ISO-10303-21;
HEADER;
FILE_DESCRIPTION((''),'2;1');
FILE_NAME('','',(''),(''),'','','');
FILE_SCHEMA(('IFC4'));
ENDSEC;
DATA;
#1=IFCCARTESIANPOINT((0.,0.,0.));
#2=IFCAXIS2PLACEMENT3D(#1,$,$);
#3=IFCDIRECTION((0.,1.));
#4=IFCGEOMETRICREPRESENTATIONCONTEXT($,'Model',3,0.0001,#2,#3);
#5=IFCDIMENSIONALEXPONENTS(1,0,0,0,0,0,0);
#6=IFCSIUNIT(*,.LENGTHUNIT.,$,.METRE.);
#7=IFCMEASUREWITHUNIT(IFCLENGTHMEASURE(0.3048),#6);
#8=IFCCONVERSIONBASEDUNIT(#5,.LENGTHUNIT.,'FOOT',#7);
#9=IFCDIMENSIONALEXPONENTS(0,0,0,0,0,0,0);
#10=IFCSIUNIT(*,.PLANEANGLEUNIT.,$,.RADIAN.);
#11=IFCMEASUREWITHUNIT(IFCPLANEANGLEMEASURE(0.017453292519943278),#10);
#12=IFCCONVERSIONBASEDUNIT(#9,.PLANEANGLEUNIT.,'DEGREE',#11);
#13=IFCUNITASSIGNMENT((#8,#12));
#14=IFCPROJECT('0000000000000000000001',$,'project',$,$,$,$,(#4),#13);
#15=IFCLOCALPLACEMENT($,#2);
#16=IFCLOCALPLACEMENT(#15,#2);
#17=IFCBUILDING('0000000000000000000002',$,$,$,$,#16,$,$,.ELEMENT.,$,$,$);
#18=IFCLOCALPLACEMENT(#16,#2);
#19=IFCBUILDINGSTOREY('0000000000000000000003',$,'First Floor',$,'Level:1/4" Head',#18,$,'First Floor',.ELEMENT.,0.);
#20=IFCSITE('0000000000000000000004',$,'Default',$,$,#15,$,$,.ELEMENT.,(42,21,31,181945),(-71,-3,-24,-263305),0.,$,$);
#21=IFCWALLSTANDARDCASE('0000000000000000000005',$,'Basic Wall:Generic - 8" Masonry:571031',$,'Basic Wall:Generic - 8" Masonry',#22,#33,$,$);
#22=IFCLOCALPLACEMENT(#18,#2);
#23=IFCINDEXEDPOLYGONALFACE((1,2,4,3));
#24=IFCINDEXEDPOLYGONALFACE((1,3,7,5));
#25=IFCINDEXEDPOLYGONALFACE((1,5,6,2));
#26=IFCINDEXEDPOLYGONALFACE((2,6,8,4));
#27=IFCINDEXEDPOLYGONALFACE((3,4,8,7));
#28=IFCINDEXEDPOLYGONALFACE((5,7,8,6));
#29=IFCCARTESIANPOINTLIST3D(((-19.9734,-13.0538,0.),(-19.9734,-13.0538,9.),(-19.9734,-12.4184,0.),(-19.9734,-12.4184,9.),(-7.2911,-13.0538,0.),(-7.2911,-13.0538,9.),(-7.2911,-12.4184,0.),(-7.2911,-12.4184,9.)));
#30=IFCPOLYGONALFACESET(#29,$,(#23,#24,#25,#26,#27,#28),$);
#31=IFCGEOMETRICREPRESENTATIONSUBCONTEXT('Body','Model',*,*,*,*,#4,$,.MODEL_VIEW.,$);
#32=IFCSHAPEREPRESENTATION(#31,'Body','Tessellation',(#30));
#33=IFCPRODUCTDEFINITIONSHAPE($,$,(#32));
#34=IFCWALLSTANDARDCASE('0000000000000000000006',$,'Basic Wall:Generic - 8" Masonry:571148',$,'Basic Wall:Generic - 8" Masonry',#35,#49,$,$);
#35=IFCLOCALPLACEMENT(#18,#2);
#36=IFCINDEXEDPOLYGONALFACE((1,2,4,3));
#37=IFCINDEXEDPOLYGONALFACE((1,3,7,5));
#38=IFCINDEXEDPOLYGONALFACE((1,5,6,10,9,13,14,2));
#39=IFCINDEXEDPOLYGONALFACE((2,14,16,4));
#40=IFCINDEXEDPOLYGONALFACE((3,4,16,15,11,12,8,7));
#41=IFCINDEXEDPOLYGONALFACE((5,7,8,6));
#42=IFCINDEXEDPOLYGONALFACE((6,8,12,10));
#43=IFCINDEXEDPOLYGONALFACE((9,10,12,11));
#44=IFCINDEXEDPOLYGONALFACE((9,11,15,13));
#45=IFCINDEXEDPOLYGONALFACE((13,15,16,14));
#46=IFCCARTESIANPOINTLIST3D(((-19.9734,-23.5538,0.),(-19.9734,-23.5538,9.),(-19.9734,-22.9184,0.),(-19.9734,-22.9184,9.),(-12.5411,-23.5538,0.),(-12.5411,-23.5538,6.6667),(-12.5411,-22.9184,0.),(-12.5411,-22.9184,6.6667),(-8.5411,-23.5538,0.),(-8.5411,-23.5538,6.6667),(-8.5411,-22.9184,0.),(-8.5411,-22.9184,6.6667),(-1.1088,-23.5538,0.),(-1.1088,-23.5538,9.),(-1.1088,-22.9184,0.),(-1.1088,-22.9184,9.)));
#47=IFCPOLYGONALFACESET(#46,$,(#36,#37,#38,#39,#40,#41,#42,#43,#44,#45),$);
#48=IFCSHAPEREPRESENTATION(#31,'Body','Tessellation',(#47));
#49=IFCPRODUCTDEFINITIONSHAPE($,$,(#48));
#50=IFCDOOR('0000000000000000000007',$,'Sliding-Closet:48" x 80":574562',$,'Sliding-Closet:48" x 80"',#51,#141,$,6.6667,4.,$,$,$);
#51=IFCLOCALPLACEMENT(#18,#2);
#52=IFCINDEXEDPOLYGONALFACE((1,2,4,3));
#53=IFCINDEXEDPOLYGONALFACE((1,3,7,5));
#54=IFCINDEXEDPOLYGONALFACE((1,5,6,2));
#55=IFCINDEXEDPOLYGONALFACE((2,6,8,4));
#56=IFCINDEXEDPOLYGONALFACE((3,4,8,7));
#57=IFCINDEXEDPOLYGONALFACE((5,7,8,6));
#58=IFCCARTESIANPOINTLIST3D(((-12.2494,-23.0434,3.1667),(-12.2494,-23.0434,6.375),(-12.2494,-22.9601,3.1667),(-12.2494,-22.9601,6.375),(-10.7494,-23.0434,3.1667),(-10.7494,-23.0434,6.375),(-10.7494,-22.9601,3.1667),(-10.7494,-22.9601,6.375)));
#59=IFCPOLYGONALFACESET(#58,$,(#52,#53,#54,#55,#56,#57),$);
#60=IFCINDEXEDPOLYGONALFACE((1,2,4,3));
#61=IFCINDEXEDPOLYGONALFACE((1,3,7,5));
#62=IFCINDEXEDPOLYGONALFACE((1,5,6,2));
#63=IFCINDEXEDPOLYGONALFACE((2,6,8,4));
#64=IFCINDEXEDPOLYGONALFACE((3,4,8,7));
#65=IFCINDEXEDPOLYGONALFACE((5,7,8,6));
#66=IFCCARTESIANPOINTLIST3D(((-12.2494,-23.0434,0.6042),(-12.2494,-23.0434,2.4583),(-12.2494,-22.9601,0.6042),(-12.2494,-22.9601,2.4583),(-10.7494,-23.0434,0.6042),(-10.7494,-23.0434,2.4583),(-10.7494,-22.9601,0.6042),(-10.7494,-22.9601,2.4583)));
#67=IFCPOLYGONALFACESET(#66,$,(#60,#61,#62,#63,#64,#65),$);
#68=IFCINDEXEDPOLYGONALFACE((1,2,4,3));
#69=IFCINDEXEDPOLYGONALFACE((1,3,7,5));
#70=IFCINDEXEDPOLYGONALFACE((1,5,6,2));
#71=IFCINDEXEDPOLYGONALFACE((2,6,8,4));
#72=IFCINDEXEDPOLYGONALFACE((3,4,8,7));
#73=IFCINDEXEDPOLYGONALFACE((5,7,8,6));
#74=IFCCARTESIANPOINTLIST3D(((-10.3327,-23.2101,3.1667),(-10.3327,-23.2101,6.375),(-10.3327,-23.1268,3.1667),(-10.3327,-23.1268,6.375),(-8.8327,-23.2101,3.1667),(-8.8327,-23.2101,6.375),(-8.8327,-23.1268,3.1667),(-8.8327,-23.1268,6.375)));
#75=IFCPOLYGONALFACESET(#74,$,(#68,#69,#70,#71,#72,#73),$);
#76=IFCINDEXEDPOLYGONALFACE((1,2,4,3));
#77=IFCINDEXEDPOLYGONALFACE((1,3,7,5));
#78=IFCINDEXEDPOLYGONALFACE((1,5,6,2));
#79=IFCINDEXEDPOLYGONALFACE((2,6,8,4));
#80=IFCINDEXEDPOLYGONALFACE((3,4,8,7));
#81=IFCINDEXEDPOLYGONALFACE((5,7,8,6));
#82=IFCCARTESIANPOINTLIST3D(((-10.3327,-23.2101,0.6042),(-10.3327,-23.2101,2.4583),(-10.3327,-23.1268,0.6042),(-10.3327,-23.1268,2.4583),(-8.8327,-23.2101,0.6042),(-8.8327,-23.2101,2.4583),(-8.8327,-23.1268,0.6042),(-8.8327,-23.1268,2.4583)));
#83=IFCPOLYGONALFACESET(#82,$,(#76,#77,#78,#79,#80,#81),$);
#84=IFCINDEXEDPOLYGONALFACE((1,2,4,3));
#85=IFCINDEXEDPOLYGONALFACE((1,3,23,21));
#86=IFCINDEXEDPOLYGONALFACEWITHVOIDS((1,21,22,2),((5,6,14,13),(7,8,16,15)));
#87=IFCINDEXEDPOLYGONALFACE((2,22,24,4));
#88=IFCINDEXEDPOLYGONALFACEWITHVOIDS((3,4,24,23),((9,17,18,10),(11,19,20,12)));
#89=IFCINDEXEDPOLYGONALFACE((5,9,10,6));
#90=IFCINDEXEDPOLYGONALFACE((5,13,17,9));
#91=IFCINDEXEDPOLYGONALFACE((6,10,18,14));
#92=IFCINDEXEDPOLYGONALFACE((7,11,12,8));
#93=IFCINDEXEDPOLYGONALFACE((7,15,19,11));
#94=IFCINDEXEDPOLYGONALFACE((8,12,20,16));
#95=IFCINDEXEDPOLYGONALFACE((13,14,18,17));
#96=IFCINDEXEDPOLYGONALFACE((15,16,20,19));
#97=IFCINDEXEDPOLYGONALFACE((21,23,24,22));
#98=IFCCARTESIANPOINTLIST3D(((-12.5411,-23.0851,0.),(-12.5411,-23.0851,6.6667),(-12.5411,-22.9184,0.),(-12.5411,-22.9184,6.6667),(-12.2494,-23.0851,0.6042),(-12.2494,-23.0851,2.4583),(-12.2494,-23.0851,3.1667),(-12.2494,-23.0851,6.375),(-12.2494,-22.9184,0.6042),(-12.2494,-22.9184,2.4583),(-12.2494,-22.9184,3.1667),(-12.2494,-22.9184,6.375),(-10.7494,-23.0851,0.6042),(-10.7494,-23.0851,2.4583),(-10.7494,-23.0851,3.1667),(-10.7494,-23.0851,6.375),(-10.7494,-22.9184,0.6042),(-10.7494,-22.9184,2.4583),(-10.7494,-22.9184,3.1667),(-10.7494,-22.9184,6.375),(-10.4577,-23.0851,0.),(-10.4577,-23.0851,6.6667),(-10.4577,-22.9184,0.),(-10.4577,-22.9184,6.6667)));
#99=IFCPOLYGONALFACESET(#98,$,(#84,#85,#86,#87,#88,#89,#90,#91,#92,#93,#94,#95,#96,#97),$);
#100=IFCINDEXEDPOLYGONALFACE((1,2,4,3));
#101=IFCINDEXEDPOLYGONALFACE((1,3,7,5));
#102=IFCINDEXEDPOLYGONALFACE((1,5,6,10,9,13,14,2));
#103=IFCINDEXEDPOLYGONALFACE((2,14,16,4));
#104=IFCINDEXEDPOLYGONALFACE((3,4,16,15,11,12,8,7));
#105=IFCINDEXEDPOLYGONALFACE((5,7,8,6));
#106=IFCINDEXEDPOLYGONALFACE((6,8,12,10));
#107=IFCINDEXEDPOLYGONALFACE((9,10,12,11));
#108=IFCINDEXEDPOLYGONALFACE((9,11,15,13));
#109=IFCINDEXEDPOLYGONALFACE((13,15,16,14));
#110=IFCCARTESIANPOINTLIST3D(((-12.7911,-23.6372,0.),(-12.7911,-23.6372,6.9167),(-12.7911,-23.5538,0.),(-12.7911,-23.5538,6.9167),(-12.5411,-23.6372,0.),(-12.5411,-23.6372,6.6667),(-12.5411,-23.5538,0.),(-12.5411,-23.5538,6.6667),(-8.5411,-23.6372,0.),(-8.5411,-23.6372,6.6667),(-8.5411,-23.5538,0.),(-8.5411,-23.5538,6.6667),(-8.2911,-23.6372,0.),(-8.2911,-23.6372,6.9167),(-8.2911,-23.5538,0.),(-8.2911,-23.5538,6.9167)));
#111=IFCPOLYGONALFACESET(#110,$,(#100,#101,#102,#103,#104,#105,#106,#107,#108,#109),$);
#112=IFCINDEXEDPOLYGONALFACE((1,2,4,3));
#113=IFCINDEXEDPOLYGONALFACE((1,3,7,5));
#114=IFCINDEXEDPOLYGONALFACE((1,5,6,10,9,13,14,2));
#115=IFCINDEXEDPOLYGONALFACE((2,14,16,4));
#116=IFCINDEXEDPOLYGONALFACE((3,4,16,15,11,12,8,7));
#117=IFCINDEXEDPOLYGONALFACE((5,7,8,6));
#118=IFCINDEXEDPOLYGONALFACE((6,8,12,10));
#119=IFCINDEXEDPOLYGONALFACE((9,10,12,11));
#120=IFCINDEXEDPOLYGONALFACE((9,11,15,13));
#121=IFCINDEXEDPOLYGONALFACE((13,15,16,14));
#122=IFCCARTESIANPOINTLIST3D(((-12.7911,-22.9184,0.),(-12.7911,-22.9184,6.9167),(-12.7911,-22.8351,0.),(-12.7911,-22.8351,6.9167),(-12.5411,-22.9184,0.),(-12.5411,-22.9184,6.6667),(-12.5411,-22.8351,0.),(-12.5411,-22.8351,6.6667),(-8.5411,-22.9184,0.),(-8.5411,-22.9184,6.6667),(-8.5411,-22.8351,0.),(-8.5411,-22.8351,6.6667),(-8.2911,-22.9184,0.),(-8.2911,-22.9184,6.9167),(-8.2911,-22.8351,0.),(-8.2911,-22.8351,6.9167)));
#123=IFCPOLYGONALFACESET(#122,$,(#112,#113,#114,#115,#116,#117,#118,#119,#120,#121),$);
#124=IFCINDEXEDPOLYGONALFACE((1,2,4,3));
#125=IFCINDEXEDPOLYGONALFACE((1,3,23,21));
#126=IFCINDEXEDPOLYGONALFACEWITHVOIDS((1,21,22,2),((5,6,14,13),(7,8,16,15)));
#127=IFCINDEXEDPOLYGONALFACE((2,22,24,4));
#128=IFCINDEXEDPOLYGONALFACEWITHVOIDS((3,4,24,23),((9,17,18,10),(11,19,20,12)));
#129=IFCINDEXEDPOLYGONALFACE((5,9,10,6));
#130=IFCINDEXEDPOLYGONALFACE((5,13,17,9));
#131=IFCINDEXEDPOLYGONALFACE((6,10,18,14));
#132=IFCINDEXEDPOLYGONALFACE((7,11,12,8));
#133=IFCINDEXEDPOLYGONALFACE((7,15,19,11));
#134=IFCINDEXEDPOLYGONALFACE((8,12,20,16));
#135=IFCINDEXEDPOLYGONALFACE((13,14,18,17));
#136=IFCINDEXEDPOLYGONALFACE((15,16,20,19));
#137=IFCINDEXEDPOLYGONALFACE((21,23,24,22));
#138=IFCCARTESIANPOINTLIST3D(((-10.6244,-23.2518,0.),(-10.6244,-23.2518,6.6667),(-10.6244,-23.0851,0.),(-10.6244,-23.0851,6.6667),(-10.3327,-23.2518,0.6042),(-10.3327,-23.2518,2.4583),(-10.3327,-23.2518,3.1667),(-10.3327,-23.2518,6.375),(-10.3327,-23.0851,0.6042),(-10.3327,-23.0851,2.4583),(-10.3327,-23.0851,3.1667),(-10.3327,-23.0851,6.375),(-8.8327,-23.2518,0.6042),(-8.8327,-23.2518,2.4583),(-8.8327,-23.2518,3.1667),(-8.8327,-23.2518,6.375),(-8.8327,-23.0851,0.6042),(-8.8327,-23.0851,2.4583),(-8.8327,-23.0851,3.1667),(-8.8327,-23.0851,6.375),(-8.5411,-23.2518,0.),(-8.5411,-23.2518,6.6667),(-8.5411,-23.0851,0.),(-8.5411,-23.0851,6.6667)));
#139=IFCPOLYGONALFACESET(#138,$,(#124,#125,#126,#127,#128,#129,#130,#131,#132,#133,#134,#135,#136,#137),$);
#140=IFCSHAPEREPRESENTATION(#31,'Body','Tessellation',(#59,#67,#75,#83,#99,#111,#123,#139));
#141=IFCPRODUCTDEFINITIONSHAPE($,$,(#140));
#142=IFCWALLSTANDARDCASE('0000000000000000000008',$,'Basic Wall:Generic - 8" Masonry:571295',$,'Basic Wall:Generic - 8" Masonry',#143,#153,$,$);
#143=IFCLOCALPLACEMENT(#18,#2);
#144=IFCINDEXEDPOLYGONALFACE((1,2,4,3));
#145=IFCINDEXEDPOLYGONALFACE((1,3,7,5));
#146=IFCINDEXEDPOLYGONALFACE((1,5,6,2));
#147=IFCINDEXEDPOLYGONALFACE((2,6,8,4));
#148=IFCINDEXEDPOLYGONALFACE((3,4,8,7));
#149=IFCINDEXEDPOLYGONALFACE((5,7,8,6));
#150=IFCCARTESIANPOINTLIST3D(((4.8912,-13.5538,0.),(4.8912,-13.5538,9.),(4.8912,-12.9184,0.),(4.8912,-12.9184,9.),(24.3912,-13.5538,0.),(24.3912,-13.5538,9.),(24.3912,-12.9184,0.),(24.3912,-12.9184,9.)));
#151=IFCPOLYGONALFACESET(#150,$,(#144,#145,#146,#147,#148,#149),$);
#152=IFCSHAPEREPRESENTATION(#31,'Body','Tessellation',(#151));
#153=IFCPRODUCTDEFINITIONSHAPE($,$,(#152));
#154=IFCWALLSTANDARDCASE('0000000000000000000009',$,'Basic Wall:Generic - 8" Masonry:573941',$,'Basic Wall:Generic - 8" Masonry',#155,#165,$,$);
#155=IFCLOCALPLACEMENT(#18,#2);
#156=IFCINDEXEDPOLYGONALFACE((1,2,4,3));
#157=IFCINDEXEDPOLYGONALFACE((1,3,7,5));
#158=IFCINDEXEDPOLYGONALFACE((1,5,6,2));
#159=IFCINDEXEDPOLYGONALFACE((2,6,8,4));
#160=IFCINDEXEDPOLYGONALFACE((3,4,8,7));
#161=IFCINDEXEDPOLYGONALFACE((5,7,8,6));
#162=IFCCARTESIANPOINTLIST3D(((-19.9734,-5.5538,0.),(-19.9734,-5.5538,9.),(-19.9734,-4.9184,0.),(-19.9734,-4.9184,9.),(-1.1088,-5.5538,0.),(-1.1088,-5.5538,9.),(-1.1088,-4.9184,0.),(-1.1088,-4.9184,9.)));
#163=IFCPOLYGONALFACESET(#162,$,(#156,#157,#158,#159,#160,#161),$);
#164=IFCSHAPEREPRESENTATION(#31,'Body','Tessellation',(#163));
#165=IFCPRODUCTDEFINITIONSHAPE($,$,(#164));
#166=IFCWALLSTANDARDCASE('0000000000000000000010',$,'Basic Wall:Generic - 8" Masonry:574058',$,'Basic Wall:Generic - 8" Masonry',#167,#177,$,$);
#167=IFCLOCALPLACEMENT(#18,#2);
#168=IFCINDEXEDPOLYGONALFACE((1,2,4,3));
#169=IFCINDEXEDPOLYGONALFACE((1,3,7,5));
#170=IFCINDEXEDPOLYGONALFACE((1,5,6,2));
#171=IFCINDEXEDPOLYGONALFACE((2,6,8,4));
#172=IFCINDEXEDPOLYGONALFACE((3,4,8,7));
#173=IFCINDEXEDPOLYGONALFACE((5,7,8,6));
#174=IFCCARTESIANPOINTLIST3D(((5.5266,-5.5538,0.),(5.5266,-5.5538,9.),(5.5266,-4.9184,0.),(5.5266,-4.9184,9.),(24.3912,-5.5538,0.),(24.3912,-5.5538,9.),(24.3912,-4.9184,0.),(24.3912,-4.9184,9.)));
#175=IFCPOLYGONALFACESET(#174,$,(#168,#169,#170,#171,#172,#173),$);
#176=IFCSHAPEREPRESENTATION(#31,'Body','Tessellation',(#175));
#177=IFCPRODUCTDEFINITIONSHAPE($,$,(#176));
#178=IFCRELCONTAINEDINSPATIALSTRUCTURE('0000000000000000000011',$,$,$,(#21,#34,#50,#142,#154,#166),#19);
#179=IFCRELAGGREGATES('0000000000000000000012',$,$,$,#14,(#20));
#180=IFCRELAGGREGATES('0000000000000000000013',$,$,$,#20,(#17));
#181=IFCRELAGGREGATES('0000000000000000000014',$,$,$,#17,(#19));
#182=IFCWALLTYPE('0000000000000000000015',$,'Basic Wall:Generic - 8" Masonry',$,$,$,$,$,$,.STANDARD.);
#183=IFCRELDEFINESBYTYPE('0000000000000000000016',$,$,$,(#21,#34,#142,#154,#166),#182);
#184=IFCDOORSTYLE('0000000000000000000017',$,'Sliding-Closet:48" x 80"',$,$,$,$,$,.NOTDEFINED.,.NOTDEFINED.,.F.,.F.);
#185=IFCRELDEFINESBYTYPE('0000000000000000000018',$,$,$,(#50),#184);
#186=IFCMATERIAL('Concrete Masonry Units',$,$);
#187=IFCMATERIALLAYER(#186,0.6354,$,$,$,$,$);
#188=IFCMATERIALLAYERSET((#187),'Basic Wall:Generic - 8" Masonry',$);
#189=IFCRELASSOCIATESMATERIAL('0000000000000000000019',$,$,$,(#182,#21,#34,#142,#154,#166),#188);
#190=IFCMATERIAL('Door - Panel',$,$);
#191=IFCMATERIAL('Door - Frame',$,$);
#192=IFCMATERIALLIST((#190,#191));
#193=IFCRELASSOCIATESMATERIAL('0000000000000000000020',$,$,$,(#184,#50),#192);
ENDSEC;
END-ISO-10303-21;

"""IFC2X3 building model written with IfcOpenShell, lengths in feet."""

from ifc_helpers import new_model, entity, si_unit, converted_unit, direction, frame, frame_2d, origin, origin_2d_with_axis, place, context, subcontext, project, spatial, polyline, rectangle, outline, extrude, source, transform, mapped, material, material_list, layer, layer_set, layer_usage, type_object, type_shapes, element, fill, save


model = new_model("IFC2X3")

# Units and contexts
model_context = context("Model", 3, precision=0.0001, world=origin(), true_north=direction((0.0, 1.0)))
body_context = subcontext(model_context, "Body", "Model", "MODEL_VIEW")
ifc_project = project(units=[converted_unit("LENGTHUNIT", "FOOT", entity("IfcLengthMeasure", 0.3048), si_unit("LENGTHUNIT", "METRE"), dimensions=[1, 0, 0, 0, 0, 0, 0]), converted_unit("PLANEANGLEUNIT", "DEGREE", entity("IfcPlaneAngleMeasure", 0.017453292519943278), si_unit("PLANEANGLEUNIT", "RADIAN"), dimensions=[0, 0, 0, 0, 0, 0, 0])], contexts=[model_context])

# Site, building, storey
site_placement = place(None, origin())
site = spatial("IfcSite", under=ifc_project, at=site_placement, Name="Default", CompositionType="ELEMENT", RefLatitude=(42, 21, 31, 181945), RefLongitude=(-71, -3, -24, -263305), RefElevation=0.0)
building_placement = place(site_placement, origin())
building = spatial("IfcBuilding", under=site, at=building_placement, CompositionType="ELEMENT")
storey_placement = place(building_placement, origin())
storey = spatial("IfcBuildingStorey", under=building, at=storey_placement, Name="First Floor", ObjectType="Level:1/4\" Head", LongName="First Floor", CompositionType="ELEMENT", Elevation=0.0)

# Wall
ifc_material_1 = material(Name="Concrete Masonry Units")
ifc_layer = layer(ifc_material_1, 0.6354)
ifc_layer_set = layer_set([ifc_layer], Name="Basic Wall:Generic - 8\" Masonry")
ifc_layer_usage_1 = layer_usage(ifc_layer_set, "AXIS2", "NEGATIVE", 0.3177)
wall_type = type_object("IfcWallType", Name="Basic Wall:Generic - 8\" Masonry", PredefinedType="STANDARD", material=ifc_layer_set)
wall_1_placement = place(storey_placement, frame((-7.2911, -12.7361, 0.0), z_axis=(0.0, 0.0, 1.0), x_axis=(-1.0, 0.0, 0.0)))
element("IfcWallStandardCase", 1, at=wall_1_placement, inside=storey, type_object=wall_type, material=ifc_layer_usage_1, Name="Basic Wall:Generic - 8\" Masonry:571031", ObjectType="Basic Wall:Generic - 8\" Masonry", context=body_context, shape_type="SweptSolid", body=[
    extrude(rectangle(XDim=12.6823, YDim=0.6354, at=frame_2d((6.3411, 0.0), x_axis=(-1.0, 0.0))), origin(), (0.0, 0.0, 1.0), 9.0),
])

# Wall, opening, door
ifc_layer_usage_2 = layer_usage(ifc_layer_set, "AXIS2", "NEGATIVE", 0.3177)
wall_2_placement = place(storey_placement, frame((-1.1088, -23.2361, 0.0), z_axis=(0.0, 0.0, 1.0), x_axis=(-1.0, 0.0, 0.0)))
wall_2 = element("IfcWallStandardCase", 2, at=wall_2_placement, inside=storey, type_object=wall_type, material=ifc_layer_usage_2, Name="Basic Wall:Generic - 8\" Masonry:571148", ObjectType="Basic Wall:Generic - 8\" Masonry", context=body_context, shape_type="SweptSolid", body=[
    extrude(rectangle(XDim=18.8646, YDim=0.6354, at=frame_2d((9.4323, 0.0), x_axis=(1.0, 0.0))), origin(), (0.0, 0.0, 1.0), 9.0),
])
opening_1_placement = place(wall_2_placement, frame((11.4323, 0.3177, 0.0)))
opening_1 = element("IfcOpeningElement", 3, at=opening_1_placement, cuts=wall_2, ObjectType="Opening", context=body_context, shape_type="SweptSolid", body=[
    extrude(rectangle(XDim=6.6667, YDim=4.0, at=frame_2d((3.3333, 2.0), x_axis=(-1.0, 0.0))), frame((0.0, 0.0, 0.0), z_axis=(0.0, -1.0, 0.0), x_axis=(0.0, 0.0, 1.0)), (0.0, 0.0, 1.0), 0.6354),
])
ifc_material_2 = material(Name="Door - Panel")
ifc_material_3 = material(Name="Door - Frame")
ifc_material_list_1 = material_list([ifc_material_2, ifc_material_3])
door_style_1 = type_object("IfcDoorStyle", Name="Sliding-Closet:48\" x 80\"", ConstructionType="NOTDEFINED", OperationType="NOTDEFINED", ParameterTakesPrecedence=False, Sizeable=False, material=ifc_material_list_1)
shared_shape_1 = source(origin(), body_context, "Body", "SweptSolid", [
    extrude(rectangle(XDim=0.0833, YDim=1.5, at=origin_2d_with_axis()), frame((1.0417, 0.5521, 3.1667), z_axis=(0.0, 0.0, 1.0), x_axis=(0.0, 1.0, 0.0)), (0.0, 0.0, 1.0), 3.2083),
    extrude(rectangle(XDim=0.0833, YDim=1.5, at=origin_2d_with_axis()), frame((1.0417, 0.5521, 0.6042), z_axis=(0.0, 0.0, 1.0), x_axis=(0.0, 1.0, 0.0)), (0.0, 0.0, 1.0), 1.8542),
    extrude(rectangle(XDim=0.0833, YDim=1.5, at=frame_2d((0.0, 0.0), x_axis=(1.0, 0.0))), frame((2.9583, 0.3854, 3.1667), z_axis=(0.0, 0.0, 1.0), x_axis=(0.0, -1.0, 0.0)), (0.0, 0.0, 1.0), 3.2083),
    extrude(rectangle(XDim=0.0833, YDim=1.5, at=frame_2d((0.0, 0.0), x_axis=(1.0, 0.0))), frame((2.9583, 0.3854, 0.6042), z_axis=(0.0, 0.0, 1.0), x_axis=(0.0, -1.0, 0.0)), (0.0, 0.0, 1.0), 1.8542),
    extrude(outline(polyline([(-3.3333, -1.0417), (3.3333, -1.0417), (3.3333, 1.0417), (-3.3333, 1.0417), (-3.3333, -1.0417)]), holes=[polyline([(2.7292, 0.75), (2.7292, -0.75), (0.875, -0.75), (0.875, 0.75), (2.7292, 0.75)]), polyline([(0.1667, 0.75), (0.1667, -0.75), (-3.0417, -0.75), (-3.0417, 0.75), (0.1667, 0.75)])]), frame((1.0417, 0.4688, 3.3333), z_axis=(0.0, 1.0, 0.0), x_axis=(0.0, 0.0, -1.0)), (0.0, 0.0, 1.0), 0.1667),
    extrude(outline(polyline([(-3.3958, -2.25), (3.5208, -2.25), (3.5208, 2.25), (-3.3958, 2.25), (-3.3958, 2.0), (3.2708, 2.0), (3.2708, -2.0), (-3.3958, -2.0), (-3.3958, -2.25)])), frame((2.0, -0.0833, 3.3958), z_axis=(0.0, 1.0, 0.0), x_axis=(0.0, 0.0, 1.0)), (0.0, 0.0, 1.0), 0.0833),
    extrude(outline(polyline([(-2.25, -3.3958), (-2.0, -3.3958), (-2.0, 3.2708), (2.0, 3.2708), (2.0, -3.3958), (2.25, -3.3958), (2.25, 3.5208), (-2.25, 3.5208), (-2.25, -3.3958)])), frame((2.0, 0.6354, 3.3958), z_axis=(0.0, 1.0, 0.0), x_axis=(-1.0, 0.0, 0.0)), (0.0, 0.0, 1.0), 0.0833),
    extrude(outline(polyline([(-1.0417, -3.3333), (1.0417, -3.3333), (1.0417, 3.3333), (-1.0417, 3.3333), (-1.0417, -3.3333)]), holes=[polyline([(0.75, 0.1667), (0.75, -3.0417), (-0.75, -3.0417), (-0.75, 0.1667), (0.75, 0.1667)]), polyline([(0.75, 2.7292), (0.75, 0.875), (-0.75, 0.875), (-0.75, 2.7292), (0.75, 2.7292)])]), frame((2.9583, 0.3021, 3.3333), z_axis=(0.0, 1.0, 0.0), x_axis=(1.0, 0.0, 0.0)), (0.0, 0.0, 1.0), 0.1667),
])
type_shapes(door_style_1, [shared_shape_1])
door_1_placement = place(opening_1_placement, frame((0.0, 0.0, 0.0), z_axis=(0.0, 0.0, 1.0), x_axis=(-1.0, 0.0, 0.0)))
door_1 = element("IfcDoor", 4, at=door_1_placement, inside=storey, type_object=door_style_1, material=ifc_material_list_1, Name="Sliding-Closet:48\" x 80\":574562", ObjectType="Sliding-Closet:48\" x 80\"", OverallHeight=6.6667, OverallWidth=4.0, context=body_context, shape_type="MappedRepresentation", body=[
    mapped(shared_shape_1, transform((0.0, 0.0, 0.0), scale=1.0)),
])
fill(opening_1, door_1)

# Wall
ifc_layer_usage_3 = layer_usage(ifc_layer_set, "AXIS2", "NEGATIVE", 0.3177)
wall_3_placement = place(storey_placement, frame((4.8912, -13.2361, 0.0)))
element("IfcWallStandardCase", 5, at=wall_3_placement, inside=storey, type_object=wall_type, material=ifc_layer_usage_3, Name="Basic Wall:Generic - 8\" Masonry:571295", ObjectType="Basic Wall:Generic - 8\" Masonry", context=body_context, shape_type="SweptSolid", body=[
    extrude(rectangle(XDim=19.5, YDim=0.6354, at=frame_2d((9.75, 0.0), x_axis=(-1.0, 0.0))), origin(), (0.0, 0.0, 1.0), 9.0),
])

# Walls
ifc_layer_usage_4 = layer_usage(ifc_layer_set, "AXIS2", "NEGATIVE", 0.3177)
wall_4_placement = place(storey_placement, frame((-1.1088, -5.2361, 0.0), z_axis=(0.0, 0.0, 1.0), x_axis=(-1.0, 0.0, 0.0)))
element("IfcWallStandardCase", 6, at=wall_4_placement, inside=storey, type_object=wall_type, material=ifc_layer_usage_4, Name="Basic Wall:Generic - 8\" Masonry:573941", ObjectType="Basic Wall:Generic - 8\" Masonry", context=body_context, shape_type="SweptSolid", body=[
    extrude(rectangle(XDim=18.8646, YDim=0.6354, at=frame_2d((9.4323, 0.0), x_axis=(-1.0, 0.0))), origin(), (0.0, 0.0, 1.0), 9.0),
])
ifc_layer_usage_5 = layer_usage(ifc_layer_set, "AXIS2", "NEGATIVE", 0.3177)
wall_5_placement = place(storey_placement, frame((5.5266, -5.2361, 0.0)))
element("IfcWallStandardCase", 7, at=wall_5_placement, inside=storey, type_object=wall_type, material=ifc_layer_usage_5, Name="Basic Wall:Generic - 8\" Masonry:574058", ObjectType="Basic Wall:Generic - 8\" Masonry", context=body_context, shape_type="SweptSolid", body=[
    extrude(rectangle(XDim=18.8646, YDim=0.6354, at=frame_2d((9.4323, 0.0), x_axis=(-1.0, 0.0))), origin(), (0.0, 0.0, 1.0), 9.0),
])

save(model, "model.ifc")
